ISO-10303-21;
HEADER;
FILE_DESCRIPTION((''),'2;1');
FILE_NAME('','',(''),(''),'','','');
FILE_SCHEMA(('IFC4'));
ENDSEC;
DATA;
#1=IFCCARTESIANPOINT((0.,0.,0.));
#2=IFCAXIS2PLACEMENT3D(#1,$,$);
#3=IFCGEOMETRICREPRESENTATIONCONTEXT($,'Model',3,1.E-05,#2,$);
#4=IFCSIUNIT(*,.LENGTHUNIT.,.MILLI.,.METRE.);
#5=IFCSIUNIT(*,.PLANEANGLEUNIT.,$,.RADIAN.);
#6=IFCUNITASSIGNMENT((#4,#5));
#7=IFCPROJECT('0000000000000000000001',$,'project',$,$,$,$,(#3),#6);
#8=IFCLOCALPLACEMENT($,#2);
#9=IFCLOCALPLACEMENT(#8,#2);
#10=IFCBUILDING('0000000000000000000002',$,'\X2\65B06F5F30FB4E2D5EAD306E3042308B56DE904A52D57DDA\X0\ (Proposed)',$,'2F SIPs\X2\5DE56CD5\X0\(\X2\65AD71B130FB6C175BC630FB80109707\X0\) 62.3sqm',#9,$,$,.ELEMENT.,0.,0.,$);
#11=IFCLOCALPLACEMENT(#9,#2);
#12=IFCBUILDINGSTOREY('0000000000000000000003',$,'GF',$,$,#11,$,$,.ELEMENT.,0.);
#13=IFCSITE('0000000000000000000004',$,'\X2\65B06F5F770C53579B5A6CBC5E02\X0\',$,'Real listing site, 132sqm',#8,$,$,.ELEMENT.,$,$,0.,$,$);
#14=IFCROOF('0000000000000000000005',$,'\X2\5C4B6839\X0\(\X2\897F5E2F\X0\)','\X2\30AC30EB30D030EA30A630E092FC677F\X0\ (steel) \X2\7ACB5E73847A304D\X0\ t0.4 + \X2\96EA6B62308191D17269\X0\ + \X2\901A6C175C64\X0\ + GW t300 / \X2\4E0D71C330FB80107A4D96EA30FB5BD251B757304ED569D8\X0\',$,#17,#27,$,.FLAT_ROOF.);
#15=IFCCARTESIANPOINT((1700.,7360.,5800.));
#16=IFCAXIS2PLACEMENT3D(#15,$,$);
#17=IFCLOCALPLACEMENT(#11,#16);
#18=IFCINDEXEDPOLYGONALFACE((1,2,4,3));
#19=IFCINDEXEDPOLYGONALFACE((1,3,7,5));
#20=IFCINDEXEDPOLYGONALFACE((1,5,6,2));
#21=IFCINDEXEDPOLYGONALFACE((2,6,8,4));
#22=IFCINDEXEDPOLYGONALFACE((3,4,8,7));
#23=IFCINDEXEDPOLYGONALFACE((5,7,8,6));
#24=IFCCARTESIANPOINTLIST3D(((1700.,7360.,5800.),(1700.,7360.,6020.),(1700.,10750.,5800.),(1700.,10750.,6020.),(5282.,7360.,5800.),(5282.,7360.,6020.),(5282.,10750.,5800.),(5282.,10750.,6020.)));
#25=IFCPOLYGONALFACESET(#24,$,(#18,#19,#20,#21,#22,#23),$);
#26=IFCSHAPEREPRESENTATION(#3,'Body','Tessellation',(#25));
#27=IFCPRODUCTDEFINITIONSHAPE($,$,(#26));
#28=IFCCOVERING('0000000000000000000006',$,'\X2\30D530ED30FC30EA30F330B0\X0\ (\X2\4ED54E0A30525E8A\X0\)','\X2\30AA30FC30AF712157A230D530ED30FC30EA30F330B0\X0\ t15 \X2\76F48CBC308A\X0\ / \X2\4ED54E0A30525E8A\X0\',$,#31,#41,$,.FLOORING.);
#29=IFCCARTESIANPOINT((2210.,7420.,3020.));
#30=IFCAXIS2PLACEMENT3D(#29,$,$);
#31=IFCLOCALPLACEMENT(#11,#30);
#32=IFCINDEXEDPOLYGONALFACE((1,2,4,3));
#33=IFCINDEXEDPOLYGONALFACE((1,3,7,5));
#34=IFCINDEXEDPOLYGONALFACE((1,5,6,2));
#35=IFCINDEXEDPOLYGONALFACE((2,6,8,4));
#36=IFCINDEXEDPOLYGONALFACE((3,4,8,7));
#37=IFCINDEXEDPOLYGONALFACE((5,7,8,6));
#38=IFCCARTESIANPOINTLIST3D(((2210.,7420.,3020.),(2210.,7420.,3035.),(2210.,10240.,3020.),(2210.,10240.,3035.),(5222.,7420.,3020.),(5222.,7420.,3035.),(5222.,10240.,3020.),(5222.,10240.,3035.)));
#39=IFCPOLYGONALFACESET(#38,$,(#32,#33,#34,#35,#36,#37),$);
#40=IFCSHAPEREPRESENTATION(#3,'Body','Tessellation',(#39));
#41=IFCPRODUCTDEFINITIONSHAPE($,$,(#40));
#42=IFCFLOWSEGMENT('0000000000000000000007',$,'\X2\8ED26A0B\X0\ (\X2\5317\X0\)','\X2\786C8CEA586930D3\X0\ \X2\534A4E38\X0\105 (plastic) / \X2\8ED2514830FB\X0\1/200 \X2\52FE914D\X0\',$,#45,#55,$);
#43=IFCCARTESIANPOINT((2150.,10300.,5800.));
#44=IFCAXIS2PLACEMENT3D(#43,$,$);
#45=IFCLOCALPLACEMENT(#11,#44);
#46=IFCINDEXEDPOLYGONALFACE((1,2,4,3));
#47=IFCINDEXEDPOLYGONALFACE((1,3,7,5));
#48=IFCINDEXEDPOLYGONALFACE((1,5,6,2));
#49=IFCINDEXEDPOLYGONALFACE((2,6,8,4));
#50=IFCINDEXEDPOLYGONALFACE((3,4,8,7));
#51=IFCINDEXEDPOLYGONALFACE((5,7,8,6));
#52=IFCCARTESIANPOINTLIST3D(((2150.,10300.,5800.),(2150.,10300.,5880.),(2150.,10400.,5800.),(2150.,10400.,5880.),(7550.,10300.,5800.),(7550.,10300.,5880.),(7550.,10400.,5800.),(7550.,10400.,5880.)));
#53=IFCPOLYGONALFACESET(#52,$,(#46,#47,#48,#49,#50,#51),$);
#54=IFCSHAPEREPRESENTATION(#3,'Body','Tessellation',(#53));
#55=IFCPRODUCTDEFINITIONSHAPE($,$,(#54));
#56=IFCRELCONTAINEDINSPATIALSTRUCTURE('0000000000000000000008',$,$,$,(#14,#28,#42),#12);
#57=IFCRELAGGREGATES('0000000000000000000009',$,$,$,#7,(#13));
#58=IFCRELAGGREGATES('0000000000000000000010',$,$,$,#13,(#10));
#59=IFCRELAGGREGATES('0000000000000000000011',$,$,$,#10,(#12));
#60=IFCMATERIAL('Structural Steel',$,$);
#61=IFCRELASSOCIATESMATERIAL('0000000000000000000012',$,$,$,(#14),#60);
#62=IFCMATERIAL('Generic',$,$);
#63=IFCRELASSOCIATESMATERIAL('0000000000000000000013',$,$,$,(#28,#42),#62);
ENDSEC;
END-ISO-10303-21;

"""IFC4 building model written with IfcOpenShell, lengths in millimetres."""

from ifc_helpers import new_model, si_unit, frame, frame_2d, origin, place, context, project, spatial, rectangle, extrude, material, element, save


model = new_model("IFC4")

# Units and contexts
model_context = context("Model", 3, precision=1e-05, world=origin())
ifc_project = project(units=[si_unit("LENGTHUNIT", "METRE", prefix="MILLI"), si_unit("PLANEANGLEUNIT", "RADIAN")], contexts=[model_context])

# Site, building, storey
site_placement = place(None, origin())
site = spatial("IfcSite", under=ifc_project, at=site_placement, Name="新潟県南魚沼市", ObjectType="Real listing site, 132sqm", CompositionType="ELEMENT", RefElevation=0.0)
building_placement = place(site_placement, origin())
building = spatial("IfcBuilding", under=site, at=building_placement, Name="新潟・中庭のある回遊動線 (Proposed)", ObjectType="2F SIPs工法(断熱・気密・耐震) 62.3sqm", CompositionType="ELEMENT", ElevationOfRefHeight=0.0, ElevationOfTerrain=0.0)
storey_placement = place(building_placement, origin())
storey = spatial("IfcBuildingStorey", under=building, at=storey_placement, Name="GF", CompositionType="ELEMENT", Elevation=0.0)

# Roof
ifc_material_1 = material(Name="Structural Steel")
for number, where, name in (
    (1, (1700.0, 7360.0, 5800.0), "屋根(西帯)"),
):
    element("IfcRoof", number, at=place(storey_placement, frame(where)), inside=storey, material=ifc_material_1, Name=name, Description="ガルバリウム鋼板 (steel) 立平葺き t0.4 + 雪止め金物 + 通気層 + GW t300 / 不燃・耐積雪・寒冷地仕様", PredefinedType="FLAT_ROOF", context=model_context, shape_type="SweptSolid", body=[
        extrude(rectangle(XDim=3582.0, YDim=3390.0, at=frame_2d((1791.0, 1695.0))), frame((1700.0, 7360.0, 5800.0)), (0.0, 0.0, 1.0), 220.0),
    ])

# Covering
ifc_material_2 = material(Name="Generic")
covering_placement = place(storey_placement, frame((2210.0, 7420.0, 3020.0)))
element("IfcCovering", 2, at=covering_placement, inside=storey, material=ifc_material_2, Name="フローリング (仕上げ床)", Description="オーク無垢フローリング t15 直貼り / 仕上げ床", PredefinedType="FLOORING", context=model_context, shape_type="SweptSolid", body=[
    extrude(rectangle(XDim=3012.0, YDim=2820.0, at=frame_2d((1506.0, 1410.0))), frame((2210.0, 7420.0, 3020.0)), (0.0, 0.0, 1.0), 15.0),
])

# Flow segment
flow_segment_placement = place(storey_placement, frame((2150.0, 10300.0, 5800.0)))
element("IfcFlowSegment", 3, at=flow_segment_placement, inside=storey, material=ifc_material_2, Name="軒樋 (北)", Description="硬質塩ビ 半丸105 (plastic) / 軒先・1/200 勾配", context=model_context, shape_type="SweptSolid", body=[
    extrude(rectangle(XDim=5400.0, YDim=100.0, at=frame_2d((2700.0, 50.0))), frame((2150.0, 10300.0, 5800.0)), (0.0, 0.0, 1.0), 80.0),
])

save(model, "model.ifc")
